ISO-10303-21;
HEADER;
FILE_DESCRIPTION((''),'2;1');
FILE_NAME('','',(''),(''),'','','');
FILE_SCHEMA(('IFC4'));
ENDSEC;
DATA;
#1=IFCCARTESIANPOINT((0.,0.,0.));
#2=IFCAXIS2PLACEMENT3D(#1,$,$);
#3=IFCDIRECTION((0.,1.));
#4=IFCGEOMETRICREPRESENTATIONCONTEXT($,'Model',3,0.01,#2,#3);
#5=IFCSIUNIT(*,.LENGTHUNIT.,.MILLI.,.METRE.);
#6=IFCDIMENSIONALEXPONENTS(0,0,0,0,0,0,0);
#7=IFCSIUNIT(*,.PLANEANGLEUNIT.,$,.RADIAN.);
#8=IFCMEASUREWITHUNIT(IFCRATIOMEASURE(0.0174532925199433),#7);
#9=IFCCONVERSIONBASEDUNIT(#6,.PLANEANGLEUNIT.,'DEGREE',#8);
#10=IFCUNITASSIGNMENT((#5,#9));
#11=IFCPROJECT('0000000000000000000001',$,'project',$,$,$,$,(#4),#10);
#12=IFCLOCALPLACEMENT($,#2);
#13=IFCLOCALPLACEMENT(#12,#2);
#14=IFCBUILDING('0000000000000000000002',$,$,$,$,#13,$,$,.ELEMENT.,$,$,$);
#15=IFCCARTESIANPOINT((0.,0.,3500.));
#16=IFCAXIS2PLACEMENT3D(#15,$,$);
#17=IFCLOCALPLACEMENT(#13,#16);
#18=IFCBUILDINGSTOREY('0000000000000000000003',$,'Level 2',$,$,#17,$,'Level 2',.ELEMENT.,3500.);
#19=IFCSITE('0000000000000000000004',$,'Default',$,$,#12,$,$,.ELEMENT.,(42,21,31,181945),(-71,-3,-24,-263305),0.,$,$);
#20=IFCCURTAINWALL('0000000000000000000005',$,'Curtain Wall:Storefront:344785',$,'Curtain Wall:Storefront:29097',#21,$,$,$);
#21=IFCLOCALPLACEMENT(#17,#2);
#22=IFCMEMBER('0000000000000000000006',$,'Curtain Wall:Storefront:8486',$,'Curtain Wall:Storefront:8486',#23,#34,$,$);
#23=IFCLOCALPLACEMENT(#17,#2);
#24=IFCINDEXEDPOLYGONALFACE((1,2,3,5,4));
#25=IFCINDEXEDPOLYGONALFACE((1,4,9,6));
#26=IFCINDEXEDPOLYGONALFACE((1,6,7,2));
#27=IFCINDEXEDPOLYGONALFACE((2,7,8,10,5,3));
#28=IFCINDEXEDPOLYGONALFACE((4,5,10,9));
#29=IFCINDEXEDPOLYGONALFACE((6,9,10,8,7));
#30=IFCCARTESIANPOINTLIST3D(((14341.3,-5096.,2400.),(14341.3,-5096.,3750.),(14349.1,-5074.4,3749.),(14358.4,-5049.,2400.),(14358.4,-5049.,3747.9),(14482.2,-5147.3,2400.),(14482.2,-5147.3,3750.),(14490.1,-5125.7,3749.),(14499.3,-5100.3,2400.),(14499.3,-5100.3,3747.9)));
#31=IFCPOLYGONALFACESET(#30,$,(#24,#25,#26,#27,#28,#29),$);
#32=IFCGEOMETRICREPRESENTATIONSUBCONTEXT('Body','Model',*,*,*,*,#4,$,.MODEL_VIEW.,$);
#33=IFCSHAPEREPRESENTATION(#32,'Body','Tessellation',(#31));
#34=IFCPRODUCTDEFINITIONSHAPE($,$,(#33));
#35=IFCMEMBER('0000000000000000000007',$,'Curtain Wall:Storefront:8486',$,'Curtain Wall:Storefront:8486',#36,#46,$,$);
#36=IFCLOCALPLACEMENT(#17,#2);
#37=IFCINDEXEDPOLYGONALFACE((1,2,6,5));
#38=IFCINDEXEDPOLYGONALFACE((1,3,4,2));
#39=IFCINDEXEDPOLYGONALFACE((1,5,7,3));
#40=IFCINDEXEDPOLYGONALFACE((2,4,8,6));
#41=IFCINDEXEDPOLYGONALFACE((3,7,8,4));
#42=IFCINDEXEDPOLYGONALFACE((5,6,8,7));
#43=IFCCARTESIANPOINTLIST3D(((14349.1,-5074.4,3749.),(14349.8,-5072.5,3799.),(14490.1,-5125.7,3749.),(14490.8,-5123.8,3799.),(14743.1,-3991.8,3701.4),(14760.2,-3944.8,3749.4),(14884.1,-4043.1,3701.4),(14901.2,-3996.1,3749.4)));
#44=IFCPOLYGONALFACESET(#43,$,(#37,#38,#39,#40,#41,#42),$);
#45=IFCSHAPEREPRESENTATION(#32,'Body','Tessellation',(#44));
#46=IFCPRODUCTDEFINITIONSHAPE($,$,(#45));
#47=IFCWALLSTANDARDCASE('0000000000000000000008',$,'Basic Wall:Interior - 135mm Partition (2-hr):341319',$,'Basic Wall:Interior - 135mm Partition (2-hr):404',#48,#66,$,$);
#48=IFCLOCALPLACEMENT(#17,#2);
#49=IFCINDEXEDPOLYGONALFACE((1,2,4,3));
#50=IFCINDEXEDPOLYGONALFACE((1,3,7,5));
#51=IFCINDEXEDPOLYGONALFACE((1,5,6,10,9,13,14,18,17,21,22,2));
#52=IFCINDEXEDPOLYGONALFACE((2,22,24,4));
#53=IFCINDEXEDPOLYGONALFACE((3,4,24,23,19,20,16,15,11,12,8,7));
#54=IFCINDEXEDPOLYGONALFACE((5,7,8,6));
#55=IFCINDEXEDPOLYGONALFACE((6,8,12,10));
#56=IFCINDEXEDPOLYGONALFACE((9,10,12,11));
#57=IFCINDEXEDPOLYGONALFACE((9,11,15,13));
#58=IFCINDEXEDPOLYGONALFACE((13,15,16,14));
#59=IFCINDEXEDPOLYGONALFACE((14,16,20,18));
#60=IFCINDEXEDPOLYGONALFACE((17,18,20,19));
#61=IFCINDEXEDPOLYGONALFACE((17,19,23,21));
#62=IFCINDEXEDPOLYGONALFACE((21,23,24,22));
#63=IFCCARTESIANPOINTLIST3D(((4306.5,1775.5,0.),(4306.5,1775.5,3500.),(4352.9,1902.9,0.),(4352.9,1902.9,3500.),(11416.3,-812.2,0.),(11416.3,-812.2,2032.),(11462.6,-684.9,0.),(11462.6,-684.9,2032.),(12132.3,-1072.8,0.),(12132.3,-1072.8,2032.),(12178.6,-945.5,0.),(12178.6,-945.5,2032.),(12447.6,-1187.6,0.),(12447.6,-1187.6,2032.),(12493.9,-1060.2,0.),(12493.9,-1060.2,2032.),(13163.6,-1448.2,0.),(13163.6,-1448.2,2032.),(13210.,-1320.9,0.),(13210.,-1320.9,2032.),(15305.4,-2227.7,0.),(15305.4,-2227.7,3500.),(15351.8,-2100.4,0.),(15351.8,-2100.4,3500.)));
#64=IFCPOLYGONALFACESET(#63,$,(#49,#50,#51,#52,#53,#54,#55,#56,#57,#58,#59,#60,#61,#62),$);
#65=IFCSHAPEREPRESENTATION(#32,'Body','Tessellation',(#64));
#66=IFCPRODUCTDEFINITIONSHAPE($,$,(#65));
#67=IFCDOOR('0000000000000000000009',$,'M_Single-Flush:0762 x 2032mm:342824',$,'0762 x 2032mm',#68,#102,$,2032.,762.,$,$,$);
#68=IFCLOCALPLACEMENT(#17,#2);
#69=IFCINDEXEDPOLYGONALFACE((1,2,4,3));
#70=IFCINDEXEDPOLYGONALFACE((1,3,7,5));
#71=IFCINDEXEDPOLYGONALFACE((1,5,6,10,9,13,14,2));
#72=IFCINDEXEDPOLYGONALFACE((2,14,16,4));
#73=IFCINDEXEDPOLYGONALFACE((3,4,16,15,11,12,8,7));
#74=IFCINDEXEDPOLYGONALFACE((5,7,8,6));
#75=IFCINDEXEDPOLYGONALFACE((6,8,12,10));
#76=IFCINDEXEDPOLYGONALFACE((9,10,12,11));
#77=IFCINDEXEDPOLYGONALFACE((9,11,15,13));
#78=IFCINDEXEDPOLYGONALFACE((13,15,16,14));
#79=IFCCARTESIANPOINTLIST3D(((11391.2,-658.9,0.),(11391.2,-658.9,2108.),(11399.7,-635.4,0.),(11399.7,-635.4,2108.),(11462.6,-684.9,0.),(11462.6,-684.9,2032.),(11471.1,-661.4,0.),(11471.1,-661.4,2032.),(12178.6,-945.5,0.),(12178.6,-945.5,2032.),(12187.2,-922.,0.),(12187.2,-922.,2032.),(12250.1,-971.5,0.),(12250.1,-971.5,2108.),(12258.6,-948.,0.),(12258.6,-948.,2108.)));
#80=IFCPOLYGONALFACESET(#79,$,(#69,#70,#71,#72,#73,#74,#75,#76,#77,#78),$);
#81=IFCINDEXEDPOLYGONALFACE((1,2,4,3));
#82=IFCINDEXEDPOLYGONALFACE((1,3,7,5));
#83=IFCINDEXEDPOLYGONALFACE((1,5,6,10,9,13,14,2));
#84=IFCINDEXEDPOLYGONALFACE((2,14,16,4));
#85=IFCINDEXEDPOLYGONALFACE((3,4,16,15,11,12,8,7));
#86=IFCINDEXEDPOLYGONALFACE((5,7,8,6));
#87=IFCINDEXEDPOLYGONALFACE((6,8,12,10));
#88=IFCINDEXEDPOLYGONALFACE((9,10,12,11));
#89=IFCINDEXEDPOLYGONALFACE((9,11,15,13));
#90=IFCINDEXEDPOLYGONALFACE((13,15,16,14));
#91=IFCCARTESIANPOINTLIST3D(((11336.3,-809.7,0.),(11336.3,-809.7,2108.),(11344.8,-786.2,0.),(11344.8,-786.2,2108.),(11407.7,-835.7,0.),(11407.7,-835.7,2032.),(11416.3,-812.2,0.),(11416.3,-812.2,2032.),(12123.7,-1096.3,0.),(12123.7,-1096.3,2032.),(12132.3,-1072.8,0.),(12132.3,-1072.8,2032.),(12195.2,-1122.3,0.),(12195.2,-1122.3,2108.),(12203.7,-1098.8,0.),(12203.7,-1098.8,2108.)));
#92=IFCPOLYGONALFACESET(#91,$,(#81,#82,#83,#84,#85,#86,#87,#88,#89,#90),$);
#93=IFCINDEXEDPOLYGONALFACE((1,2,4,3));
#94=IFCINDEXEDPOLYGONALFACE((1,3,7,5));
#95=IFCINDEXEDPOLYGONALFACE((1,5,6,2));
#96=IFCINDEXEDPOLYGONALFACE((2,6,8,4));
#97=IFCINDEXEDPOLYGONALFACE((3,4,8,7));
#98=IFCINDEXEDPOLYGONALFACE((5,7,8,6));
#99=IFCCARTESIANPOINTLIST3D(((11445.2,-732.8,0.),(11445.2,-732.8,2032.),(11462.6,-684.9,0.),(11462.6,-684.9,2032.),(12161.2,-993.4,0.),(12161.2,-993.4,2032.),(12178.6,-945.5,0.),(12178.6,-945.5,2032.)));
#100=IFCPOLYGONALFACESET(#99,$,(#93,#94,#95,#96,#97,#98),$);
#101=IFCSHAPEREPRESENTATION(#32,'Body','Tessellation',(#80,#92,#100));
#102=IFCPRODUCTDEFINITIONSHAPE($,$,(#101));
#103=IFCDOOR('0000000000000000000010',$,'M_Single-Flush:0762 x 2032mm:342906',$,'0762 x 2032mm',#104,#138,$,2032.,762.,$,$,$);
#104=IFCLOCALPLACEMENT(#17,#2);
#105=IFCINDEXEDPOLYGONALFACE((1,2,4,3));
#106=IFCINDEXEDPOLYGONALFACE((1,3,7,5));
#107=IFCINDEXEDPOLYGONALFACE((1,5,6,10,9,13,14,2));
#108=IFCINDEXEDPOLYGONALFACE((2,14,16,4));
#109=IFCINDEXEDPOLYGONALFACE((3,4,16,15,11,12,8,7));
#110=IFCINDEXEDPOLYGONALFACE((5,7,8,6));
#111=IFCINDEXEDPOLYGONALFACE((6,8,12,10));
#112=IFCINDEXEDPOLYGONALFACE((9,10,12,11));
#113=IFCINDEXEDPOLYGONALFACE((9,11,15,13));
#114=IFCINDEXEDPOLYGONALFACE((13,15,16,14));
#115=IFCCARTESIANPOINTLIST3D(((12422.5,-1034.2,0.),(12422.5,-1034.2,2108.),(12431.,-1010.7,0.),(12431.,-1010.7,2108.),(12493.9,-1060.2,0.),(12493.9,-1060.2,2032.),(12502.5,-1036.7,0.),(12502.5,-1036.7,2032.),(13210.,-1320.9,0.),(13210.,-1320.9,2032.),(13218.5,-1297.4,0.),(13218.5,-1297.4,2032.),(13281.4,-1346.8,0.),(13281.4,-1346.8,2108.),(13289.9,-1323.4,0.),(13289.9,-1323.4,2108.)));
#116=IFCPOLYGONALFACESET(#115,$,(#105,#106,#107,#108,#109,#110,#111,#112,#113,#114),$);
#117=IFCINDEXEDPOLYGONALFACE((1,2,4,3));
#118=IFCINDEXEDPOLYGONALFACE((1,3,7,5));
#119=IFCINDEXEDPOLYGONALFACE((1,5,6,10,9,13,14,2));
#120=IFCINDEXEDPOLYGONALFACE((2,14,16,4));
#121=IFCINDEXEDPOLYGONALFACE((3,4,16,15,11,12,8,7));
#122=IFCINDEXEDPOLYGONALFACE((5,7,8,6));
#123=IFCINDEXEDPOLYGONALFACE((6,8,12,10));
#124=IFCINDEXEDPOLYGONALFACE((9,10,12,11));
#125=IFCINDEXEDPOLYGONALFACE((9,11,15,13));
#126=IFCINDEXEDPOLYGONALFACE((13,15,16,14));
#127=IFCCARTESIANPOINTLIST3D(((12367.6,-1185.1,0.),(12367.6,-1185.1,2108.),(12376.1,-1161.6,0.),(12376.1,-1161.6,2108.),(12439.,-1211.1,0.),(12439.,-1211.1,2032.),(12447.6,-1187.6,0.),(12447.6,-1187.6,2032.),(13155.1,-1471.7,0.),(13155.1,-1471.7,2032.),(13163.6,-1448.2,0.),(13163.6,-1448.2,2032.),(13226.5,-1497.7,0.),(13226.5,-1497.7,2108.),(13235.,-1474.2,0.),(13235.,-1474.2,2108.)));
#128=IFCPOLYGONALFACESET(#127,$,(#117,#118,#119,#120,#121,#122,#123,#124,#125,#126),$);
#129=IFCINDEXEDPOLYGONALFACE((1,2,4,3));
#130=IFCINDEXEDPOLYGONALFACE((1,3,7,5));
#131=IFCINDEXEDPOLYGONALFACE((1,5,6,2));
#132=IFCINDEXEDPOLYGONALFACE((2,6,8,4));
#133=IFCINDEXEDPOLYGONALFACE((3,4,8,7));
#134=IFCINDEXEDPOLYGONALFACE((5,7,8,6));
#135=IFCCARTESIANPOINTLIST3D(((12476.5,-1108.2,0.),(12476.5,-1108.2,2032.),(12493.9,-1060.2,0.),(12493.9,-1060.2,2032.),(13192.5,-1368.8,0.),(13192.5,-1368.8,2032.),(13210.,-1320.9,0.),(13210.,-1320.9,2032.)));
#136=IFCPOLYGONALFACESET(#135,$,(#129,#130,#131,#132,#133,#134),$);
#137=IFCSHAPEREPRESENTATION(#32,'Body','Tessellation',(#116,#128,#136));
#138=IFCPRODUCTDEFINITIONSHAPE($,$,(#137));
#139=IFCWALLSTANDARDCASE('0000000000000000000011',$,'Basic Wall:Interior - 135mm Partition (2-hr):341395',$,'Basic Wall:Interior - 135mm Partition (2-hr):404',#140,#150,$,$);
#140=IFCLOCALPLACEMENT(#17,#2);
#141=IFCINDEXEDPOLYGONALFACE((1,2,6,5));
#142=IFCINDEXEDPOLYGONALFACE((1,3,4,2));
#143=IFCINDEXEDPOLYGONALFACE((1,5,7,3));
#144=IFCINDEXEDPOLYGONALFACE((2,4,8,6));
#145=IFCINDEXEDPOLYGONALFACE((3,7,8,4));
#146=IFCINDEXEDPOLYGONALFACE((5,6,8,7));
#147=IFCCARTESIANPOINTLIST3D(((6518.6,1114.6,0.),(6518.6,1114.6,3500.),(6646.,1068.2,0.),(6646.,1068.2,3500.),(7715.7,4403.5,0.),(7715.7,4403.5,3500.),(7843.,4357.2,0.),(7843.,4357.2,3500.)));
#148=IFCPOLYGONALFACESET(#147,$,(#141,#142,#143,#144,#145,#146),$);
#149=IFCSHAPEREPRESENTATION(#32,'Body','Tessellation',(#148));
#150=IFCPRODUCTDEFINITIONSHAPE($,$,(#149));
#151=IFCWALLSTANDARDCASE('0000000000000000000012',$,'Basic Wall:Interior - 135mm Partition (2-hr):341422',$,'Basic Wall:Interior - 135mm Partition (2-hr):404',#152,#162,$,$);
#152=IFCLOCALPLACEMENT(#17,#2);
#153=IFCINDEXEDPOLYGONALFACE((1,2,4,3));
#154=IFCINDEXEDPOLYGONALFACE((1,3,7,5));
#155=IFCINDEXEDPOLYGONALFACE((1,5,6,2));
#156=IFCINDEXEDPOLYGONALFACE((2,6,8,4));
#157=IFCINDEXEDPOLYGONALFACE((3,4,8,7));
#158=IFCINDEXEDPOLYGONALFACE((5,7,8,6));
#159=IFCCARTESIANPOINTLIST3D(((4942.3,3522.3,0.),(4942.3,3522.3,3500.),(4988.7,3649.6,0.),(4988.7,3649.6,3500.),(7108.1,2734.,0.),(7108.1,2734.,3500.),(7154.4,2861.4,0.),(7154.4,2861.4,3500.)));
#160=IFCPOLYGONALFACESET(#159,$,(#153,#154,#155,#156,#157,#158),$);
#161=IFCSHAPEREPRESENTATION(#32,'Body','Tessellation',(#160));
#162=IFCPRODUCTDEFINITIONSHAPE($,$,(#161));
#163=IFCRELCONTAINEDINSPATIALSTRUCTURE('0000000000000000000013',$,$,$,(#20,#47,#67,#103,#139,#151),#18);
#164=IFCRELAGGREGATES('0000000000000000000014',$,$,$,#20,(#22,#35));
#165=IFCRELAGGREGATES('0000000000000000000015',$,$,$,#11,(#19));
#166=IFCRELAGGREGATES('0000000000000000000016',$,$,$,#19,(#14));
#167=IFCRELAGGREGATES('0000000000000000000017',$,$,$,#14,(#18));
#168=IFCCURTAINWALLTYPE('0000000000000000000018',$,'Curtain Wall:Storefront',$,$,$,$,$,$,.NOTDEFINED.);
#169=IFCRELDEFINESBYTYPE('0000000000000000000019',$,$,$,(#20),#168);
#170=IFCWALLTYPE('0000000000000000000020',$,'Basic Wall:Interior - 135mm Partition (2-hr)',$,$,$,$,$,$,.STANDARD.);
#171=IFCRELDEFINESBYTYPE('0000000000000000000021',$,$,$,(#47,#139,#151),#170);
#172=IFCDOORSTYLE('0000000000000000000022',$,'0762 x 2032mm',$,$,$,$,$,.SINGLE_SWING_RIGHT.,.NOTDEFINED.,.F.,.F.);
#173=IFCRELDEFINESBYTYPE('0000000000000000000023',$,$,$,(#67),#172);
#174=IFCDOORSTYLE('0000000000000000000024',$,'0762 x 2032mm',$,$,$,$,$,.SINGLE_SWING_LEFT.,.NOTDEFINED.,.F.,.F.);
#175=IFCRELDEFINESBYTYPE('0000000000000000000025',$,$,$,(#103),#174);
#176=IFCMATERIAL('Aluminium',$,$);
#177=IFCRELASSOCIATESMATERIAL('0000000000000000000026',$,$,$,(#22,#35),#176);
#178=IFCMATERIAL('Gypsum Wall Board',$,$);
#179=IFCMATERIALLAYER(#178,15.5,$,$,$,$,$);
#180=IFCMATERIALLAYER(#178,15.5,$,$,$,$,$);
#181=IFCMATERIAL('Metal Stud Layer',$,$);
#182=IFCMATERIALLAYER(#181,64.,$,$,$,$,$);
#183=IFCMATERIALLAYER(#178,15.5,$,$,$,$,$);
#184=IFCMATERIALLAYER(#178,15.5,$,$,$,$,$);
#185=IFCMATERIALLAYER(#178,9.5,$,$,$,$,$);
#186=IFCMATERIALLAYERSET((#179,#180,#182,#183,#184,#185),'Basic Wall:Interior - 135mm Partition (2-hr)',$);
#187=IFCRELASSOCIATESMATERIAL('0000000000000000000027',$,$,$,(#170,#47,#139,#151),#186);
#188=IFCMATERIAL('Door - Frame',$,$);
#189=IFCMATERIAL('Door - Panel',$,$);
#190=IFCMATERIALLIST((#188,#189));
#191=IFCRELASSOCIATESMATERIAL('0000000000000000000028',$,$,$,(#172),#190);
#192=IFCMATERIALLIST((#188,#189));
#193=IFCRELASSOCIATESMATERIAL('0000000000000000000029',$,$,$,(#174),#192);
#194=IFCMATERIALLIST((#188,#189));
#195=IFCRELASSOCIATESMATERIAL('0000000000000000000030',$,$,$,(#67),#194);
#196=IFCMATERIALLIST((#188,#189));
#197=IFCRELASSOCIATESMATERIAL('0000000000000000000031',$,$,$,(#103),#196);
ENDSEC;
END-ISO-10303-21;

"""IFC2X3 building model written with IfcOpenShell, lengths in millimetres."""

from ifc_helpers import new_model, entity, si_unit, converted_unit, direction, frame, frame_2d, origin, place, context, subcontext, project, spatial, polyline, rectangle, outline, extrude, clip, halfspace, bounded_halfspace, source, transform, mapped, material, material_list, layer, layer_set, layer_usage, type_object, type_shapes, element, fill, aggregate, save


model = new_model("IFC2X3")

# Units and contexts
model_context = context("Model", 3, precision=0.01, world=origin(), true_north=direction((0.0, 1.0)))
body_context = subcontext(model_context, "Body", "Model", "MODEL_VIEW")
ifc_project = project(units=[si_unit("LENGTHUNIT", "METRE", prefix="MILLI"), converted_unit("PLANEANGLEUNIT", "DEGREE", entity("IfcRatioMeasure", 0.0174532925199433), si_unit("PLANEANGLEUNIT", "RADIAN"), dimensions=[0, 0, 0, 0, 0, 0, 0])], contexts=[model_context])

# Site, building, storey
site_placement = place(None, origin())
site = spatial("IfcSite", under=ifc_project, at=site_placement, Name="Default", CompositionType="ELEMENT", RefLatitude=(42, 21, 31, 181945), RefLongitude=(-71, -3, -24, -263305), RefElevation=0.0)
building_placement = place(site_placement, origin())
building = spatial("IfcBuilding", under=site, at=building_placement, CompositionType="ELEMENT")
storey_placement = place(building_placement, frame((0.0, 0.0, 3500.0)))
storey = spatial("IfcBuildingStorey", under=building, at=storey_placement, Name="Level 2", LongName="Level 2", CompositionType="ELEMENT", Elevation=3500.0)

# Curtain wall, members
curtain_wall_type = type_object("IfcCurtainWallType", Name="Curtain Wall:Storefront", PredefinedType="NOTDEFINED")
curtain_wall_placement = place(storey_placement, frame((0.0, 0.0, -3500.0)))
curtain_wall = element("IfcCurtainWall", 1, at=curtain_wall_placement, inside=storey, type_object=curtain_wall_type, Name="Curtain Wall:Storefront:344785", ObjectType="Curtain Wall:Storefront:29097")
ifc_material_1 = material(Name="Aluminium")
member_1_placement = place(curtain_wall_placement, frame((0.0, 0.0, 3500.0)))
member_1 = element("IfcMember", 2, at=member_1_placement, material=ifc_material_1, Name="Curtain Wall:Storefront:8486", ObjectType="Curtain Wall:Storefront:8486", context=body_context, shape_type="Clipping", body=[
    clip(clip(extrude(rectangle(XDim=150.0, YDim=50.0, at=frame_2d((0.0, 0.0), x_axis=(1.0, 0.0))), frame((14420.3, -5098.1, 2400.0), z_axis=(0.0, 0.0, 1.0), x_axis=(0.939693, -0.34202, 0.0)), (0.0, 0.0, 1.0), 1350.0), bounded_halfspace(frame((14349.1, -5074.4, 3749.0), z_axis=(0.014121, 0.038797, 0.999147), x_axis=(0.341729, 0.938891, -0.041287)), False, frame((14420.3, -5098.1, 2400.0), z_axis=(0.0, 0.0, 1.0), x_axis=(0.939693, -0.34202, 0.0)), polyline([(75.0, -2.1), (75.0, 25.0), (-75.0, 25.0), (-75.0, -2.1), (75.0, -2.1)]))), bounded_halfspace(frame((13938.7, -6202.0, 3798.6), z_axis=(0.014121, 0.038797, 0.999147), x_axis=(0.341729, 0.938891, -0.041287)), False, frame((14420.3, -5098.1, 2400.0), z_axis=(0.0, 0.0, 1.0), x_axis=(0.939693, -0.34202, 0.0)), polyline([(-75.0, -25.0), (75.0, -25.0), (75.0, -2.1), (-75.0, -2.1), (-75.0, -25.0)]))),
])
member_2_placement = place(curtain_wall_placement, frame((0.0, 0.0, 3500.0)))
member_2 = element("IfcMember", 3, at=member_2_placement, material=ifc_material_1, Name="Curtain Wall:Storefront:8486", ObjectType="Curtain Wall:Storefront:8486", context=body_context, shape_type="Clipping", body=[
    clip(extrude(rectangle(XDim=50.0, YDim=150.0, at=frame_2d((0.0, 0.0), x_axis=(1.0, 0.0))), frame((14419.9, -5099.1, 3774.0), z_axis=(0.341729, 0.938891, -0.041287), x_axis=(-0.014121, -0.038797, -0.999147)), (0.0, 0.0, 1.0), 1201.0), halfspace(frame((15117.1, -4074.7, 3749.4), z_axis=(0.2368, 0.650602, -0.721556), x_axis=(-0.246787, -0.678041, -0.692356)), False)),
])
aggregate(curtain_wall, [member_1, member_2])

# Wall, openings, doors
ifc_material_2 = material(Name="Gypsum Wall Board")
ifc_layer_1 = layer(ifc_material_2, 15.5)
ifc_layer_2 = layer(ifc_material_2, 15.5)
ifc_material_3 = material(Name="Metal Stud Layer")
ifc_layer_3 = layer(ifc_material_3, 64.0)
ifc_layer_4 = layer(ifc_material_2, 15.5)
ifc_layer_5 = layer(ifc_material_2, 15.5)
ifc_layer_6 = layer(ifc_material_2, 9.5)
ifc_layer_set_1 = layer_set([ifc_layer_1, ifc_layer_2, ifc_layer_3, ifc_layer_4, ifc_layer_5, ifc_layer_6], Name="Basic Wall:Interior - 135mm Partition (2-hr)")
wall_type_1 = type_object("IfcWallType", Name="Basic Wall:Interior - 135mm Partition (2-hr)", PredefinedType="STANDARD", material=ifc_layer_set_1)
ifc_material_4 = material(Name="Door - Frame")
ifc_material_5 = material(Name="Door - Panel")
ifc_material_list_1 = material_list([ifc_material_4, ifc_material_5])
door_style_1 = type_object("IfcDoorStyle", Name="0762 x 2032mm", ConstructionType="NOTDEFINED", OperationType="SINGLE_SWING_RIGHT", ParameterTakesPrecedence=False, Sizeable=False, material=ifc_material_list_1)
shared_shape_1 = source(origin(), body_context, "Body", "SweptSolid", [
    extrude(outline(polyline([(-457.0, -1073.0), (457.0, -1073.0), (457.0, 1035.0), (381.0, 1035.0), (381.0, -997.0), (-381.0, -997.0), (-381.0, 1035.0), (-457.0, 1035.0), (-457.0, -1073.0)])), frame((381.0, 135.5, 1035.0), z_axis=(0.0, 1.0, 0.0), x_axis=(1.0, 0.0, 0.0)), (0.0, 0.0, 1.0), 25.0),
    extrude(outline(polyline([(-1073.0, -457.0), (1035.0, -457.0), (1035.0, -381.0), (-997.0, -381.0), (-997.0, 381.0), (1035.0, 381.0), (1035.0, 457.0), (-1073.0, 457.0), (-1073.0, -457.0)])), frame((381.0, -25.0, 1035.0), z_axis=(0.0, 1.0, 0.0), x_axis=(0.0, 0.0, -1.0)), (0.0, 0.0, 1.0), 25.0),
    extrude(rectangle(XDim=51.0, YDim=762.0, at=frame_2d((0.0, 0.0), x_axis=(1.0, 0.0))), frame((381.0, 110.0, 0.0), z_axis=(0.0, 0.0, 1.0), x_axis=(0.0, 1.0, 0.0)), (0.0, 0.0, 1.0), 2032.0),
])
type_shapes(door_style_1, [shared_shape_1])
ifc_material_list_2 = material_list([ifc_material_4, ifc_material_5])
door_style_2 = type_object("IfcDoorStyle", Name="0762 x 2032mm", ConstructionType="NOTDEFINED", OperationType="SINGLE_SWING_LEFT", ParameterTakesPrecedence=False, Sizeable=False, material=ifc_material_list_2)
shared_shape_2 = source(origin(), body_context, "Body", "SweptSolid", [
    extrude(outline(polyline([(-457.0, -1073.0), (457.0, -1073.0), (457.0, 1035.0), (381.0, 1035.0), (381.0, -997.0), (-381.0, -997.0), (-381.0, 1035.0), (-457.0, 1035.0), (-457.0, -1073.0)])), frame((381.0, 160.5, 1035.0), z_axis=(0.0, -1.0, 0.0), x_axis=(-1.0, 0.0, 0.0)), (0.0, 0.0, 1.0), 25.0),
    extrude(outline(polyline([(-1073.0, -457.0), (1035.0, -457.0), (1035.0, -381.0), (-997.0, -381.0), (-997.0, 381.0), (1035.0, 381.0), (1035.0, 457.0), (-1073.0, 457.0), (-1073.0, -457.0)])), frame((381.0, 0.0, 1035.0), z_axis=(0.0, -1.0, 0.0), x_axis=(0.0, 0.0, -1.0)), (0.0, 0.0, 1.0), 25.0),
    extrude(rectangle(XDim=762.0, YDim=51.0, at=frame_2d((0.0, 0.0), x_axis=(1.0, 0.0))), frame((381.0, 110.0, 0.0)), (0.0, 0.0, 1.0), 2032.0),
])
type_shapes(door_style_2, [shared_shape_2])
ifc_layer_usage_1 = layer_usage(ifc_layer_set_1, "AXIS2", "NEGATIVE", 67.8)
wall_1_placement = place(storey_placement, frame((4329.7, 1839.2, 0.0), z_axis=(0.0, 0.0, 1.0), x_axis=(0.939693, -0.34202, 0.0)))
wall_1 = element("IfcWallStandardCase", 4, at=wall_1_placement, inside=storey, type_object=wall_type_1, material=ifc_layer_usage_1, Name="Basic Wall:Interior - 135mm Partition (2-hr):341319", ObjectType="Basic Wall:Interior - 135mm Partition (2-hr):404", context=body_context, shape_type="SweptSolid", body=[
    extrude(rectangle(XDim=11704.8, YDim=135.5, at=frame_2d((5852.4, 0.0), x_axis=(-1.0, 0.0))), origin(), (0.0, 0.0, 1.0), 3500.0),
])
opening_1_placement = place(wall_1_placement, frame((7566.0, -67.8, 0.0)))
opening_1 = element("IfcOpeningElement", 5, at=opening_1_placement, cuts=wall_1, ObjectType="Opening", context=body_context, shape_type="SweptSolid", body=[
    extrude(rectangle(XDim=762.0, YDim=2032.0, at=frame_2d((1016.0, 381.0), x_axis=(0.0, 1.0))), frame((0.0, 0.0, 0.0), z_axis=(0.0, 1.0, 0.0), x_axis=(0.0, 0.0, 1.0)), (0.0, 0.0, 1.0), 135.5),
])
opening_2_placement = place(wall_1_placement, frame((8663.5, -67.8, 0.0)))
opening_2 = element("IfcOpeningElement", 6, at=opening_2_placement, cuts=wall_1, ObjectType="Opening", context=body_context, shape_type="SweptSolid", body=[
    extrude(rectangle(XDim=762.0, YDim=2032.0, at=frame_2d((1016.0, 381.0), x_axis=(0.0, -1.0))), frame((0.0, 0.0, 0.0), z_axis=(0.0, 1.0, 0.0), x_axis=(0.0, 0.0, 1.0)), (0.0, 0.0, 1.0), 135.5),
])
ifc_material_list_3 = material_list([ifc_material_4, ifc_material_5])
door_1_placement = place(opening_1_placement, origin())
door_1 = element("IfcDoor", 7, at=door_1_placement, inside=storey, type_object=door_style_1, material=ifc_material_list_3, Name="M_Single-Flush:0762 x 2032mm:342824", ObjectType="0762 x 2032mm", OverallHeight=2032.0, OverallWidth=762.0, context=body_context, shape_type="MappedRepresentation", body=[
    mapped(shared_shape_1, transform((0.0, 0.0, 0.0), scale=1.0)),
])
fill(opening_1, door_1)
ifc_material_list_4 = material_list([ifc_material_4, ifc_material_5])
door_2_placement = place(opening_2_placement, origin())
door_2 = element("IfcDoor", 8, at=door_2_placement, inside=storey, type_object=door_style_2, material=ifc_material_list_4, Name="M_Single-Flush:0762 x 2032mm:342906", ObjectType="0762 x 2032mm", OverallHeight=2032.0, OverallWidth=762.0, context=body_context, shape_type="MappedRepresentation", body=[
    mapped(shared_shape_2, transform((0.0, 0.0, 0.0), scale=1.0)),
])
fill(opening_2, door_2)

# Walls
ifc_layer_usage_2 = layer_usage(ifc_layer_set_1, "AXIS2", "NEGATIVE", 67.8)
wall_2_placement = place(storey_placement, frame((6582.3, 1091.4, 0.0), z_axis=(0.0, 0.0, 1.0), x_axis=(0.34202, 0.939693, 0.0)))
element("IfcWallStandardCase", 9, at=wall_2_placement, inside=storey, type_object=wall_type_1, material=ifc_layer_usage_2, Name="Basic Wall:Interior - 135mm Partition (2-hr):341395", ObjectType="Basic Wall:Interior - 135mm Partition (2-hr):404", context=body_context, shape_type="SweptSolid", body=[
    extrude(rectangle(XDim=3500.0, YDim=135.5, at=frame_2d((1750.0, 0.0), x_axis=(-1.0, 0.0))), origin(), (0.0, 0.0, 1.0), 3500.0),
])
ifc_layer_usage_3 = layer_usage(ifc_layer_set_1, "AXIS2", "NEGATIVE", 67.8)
wall_3_placement = place(storey_placement, frame((4965.5, 3586.0, 0.0), z_axis=(0.0, 0.0, 1.0), x_axis=(0.939693, -0.34202, 0.0)))
element("IfcWallStandardCase", 10, at=wall_3_placement, inside=storey, type_object=wall_type_1, material=ifc_layer_usage_3, Name="Basic Wall:Interior - 135mm Partition (2-hr):341422", ObjectType="Basic Wall:Interior - 135mm Partition (2-hr):404", context=body_context, shape_type="SweptSolid", body=[
    extrude(rectangle(XDim=2304.8, YDim=135.5, at=frame_2d((1152.4, 0.0), x_axis=(-1.0, 0.0))), origin(), (0.0, 0.0, 1.0), 3500.0),
])

save(model, "model.ifc")
